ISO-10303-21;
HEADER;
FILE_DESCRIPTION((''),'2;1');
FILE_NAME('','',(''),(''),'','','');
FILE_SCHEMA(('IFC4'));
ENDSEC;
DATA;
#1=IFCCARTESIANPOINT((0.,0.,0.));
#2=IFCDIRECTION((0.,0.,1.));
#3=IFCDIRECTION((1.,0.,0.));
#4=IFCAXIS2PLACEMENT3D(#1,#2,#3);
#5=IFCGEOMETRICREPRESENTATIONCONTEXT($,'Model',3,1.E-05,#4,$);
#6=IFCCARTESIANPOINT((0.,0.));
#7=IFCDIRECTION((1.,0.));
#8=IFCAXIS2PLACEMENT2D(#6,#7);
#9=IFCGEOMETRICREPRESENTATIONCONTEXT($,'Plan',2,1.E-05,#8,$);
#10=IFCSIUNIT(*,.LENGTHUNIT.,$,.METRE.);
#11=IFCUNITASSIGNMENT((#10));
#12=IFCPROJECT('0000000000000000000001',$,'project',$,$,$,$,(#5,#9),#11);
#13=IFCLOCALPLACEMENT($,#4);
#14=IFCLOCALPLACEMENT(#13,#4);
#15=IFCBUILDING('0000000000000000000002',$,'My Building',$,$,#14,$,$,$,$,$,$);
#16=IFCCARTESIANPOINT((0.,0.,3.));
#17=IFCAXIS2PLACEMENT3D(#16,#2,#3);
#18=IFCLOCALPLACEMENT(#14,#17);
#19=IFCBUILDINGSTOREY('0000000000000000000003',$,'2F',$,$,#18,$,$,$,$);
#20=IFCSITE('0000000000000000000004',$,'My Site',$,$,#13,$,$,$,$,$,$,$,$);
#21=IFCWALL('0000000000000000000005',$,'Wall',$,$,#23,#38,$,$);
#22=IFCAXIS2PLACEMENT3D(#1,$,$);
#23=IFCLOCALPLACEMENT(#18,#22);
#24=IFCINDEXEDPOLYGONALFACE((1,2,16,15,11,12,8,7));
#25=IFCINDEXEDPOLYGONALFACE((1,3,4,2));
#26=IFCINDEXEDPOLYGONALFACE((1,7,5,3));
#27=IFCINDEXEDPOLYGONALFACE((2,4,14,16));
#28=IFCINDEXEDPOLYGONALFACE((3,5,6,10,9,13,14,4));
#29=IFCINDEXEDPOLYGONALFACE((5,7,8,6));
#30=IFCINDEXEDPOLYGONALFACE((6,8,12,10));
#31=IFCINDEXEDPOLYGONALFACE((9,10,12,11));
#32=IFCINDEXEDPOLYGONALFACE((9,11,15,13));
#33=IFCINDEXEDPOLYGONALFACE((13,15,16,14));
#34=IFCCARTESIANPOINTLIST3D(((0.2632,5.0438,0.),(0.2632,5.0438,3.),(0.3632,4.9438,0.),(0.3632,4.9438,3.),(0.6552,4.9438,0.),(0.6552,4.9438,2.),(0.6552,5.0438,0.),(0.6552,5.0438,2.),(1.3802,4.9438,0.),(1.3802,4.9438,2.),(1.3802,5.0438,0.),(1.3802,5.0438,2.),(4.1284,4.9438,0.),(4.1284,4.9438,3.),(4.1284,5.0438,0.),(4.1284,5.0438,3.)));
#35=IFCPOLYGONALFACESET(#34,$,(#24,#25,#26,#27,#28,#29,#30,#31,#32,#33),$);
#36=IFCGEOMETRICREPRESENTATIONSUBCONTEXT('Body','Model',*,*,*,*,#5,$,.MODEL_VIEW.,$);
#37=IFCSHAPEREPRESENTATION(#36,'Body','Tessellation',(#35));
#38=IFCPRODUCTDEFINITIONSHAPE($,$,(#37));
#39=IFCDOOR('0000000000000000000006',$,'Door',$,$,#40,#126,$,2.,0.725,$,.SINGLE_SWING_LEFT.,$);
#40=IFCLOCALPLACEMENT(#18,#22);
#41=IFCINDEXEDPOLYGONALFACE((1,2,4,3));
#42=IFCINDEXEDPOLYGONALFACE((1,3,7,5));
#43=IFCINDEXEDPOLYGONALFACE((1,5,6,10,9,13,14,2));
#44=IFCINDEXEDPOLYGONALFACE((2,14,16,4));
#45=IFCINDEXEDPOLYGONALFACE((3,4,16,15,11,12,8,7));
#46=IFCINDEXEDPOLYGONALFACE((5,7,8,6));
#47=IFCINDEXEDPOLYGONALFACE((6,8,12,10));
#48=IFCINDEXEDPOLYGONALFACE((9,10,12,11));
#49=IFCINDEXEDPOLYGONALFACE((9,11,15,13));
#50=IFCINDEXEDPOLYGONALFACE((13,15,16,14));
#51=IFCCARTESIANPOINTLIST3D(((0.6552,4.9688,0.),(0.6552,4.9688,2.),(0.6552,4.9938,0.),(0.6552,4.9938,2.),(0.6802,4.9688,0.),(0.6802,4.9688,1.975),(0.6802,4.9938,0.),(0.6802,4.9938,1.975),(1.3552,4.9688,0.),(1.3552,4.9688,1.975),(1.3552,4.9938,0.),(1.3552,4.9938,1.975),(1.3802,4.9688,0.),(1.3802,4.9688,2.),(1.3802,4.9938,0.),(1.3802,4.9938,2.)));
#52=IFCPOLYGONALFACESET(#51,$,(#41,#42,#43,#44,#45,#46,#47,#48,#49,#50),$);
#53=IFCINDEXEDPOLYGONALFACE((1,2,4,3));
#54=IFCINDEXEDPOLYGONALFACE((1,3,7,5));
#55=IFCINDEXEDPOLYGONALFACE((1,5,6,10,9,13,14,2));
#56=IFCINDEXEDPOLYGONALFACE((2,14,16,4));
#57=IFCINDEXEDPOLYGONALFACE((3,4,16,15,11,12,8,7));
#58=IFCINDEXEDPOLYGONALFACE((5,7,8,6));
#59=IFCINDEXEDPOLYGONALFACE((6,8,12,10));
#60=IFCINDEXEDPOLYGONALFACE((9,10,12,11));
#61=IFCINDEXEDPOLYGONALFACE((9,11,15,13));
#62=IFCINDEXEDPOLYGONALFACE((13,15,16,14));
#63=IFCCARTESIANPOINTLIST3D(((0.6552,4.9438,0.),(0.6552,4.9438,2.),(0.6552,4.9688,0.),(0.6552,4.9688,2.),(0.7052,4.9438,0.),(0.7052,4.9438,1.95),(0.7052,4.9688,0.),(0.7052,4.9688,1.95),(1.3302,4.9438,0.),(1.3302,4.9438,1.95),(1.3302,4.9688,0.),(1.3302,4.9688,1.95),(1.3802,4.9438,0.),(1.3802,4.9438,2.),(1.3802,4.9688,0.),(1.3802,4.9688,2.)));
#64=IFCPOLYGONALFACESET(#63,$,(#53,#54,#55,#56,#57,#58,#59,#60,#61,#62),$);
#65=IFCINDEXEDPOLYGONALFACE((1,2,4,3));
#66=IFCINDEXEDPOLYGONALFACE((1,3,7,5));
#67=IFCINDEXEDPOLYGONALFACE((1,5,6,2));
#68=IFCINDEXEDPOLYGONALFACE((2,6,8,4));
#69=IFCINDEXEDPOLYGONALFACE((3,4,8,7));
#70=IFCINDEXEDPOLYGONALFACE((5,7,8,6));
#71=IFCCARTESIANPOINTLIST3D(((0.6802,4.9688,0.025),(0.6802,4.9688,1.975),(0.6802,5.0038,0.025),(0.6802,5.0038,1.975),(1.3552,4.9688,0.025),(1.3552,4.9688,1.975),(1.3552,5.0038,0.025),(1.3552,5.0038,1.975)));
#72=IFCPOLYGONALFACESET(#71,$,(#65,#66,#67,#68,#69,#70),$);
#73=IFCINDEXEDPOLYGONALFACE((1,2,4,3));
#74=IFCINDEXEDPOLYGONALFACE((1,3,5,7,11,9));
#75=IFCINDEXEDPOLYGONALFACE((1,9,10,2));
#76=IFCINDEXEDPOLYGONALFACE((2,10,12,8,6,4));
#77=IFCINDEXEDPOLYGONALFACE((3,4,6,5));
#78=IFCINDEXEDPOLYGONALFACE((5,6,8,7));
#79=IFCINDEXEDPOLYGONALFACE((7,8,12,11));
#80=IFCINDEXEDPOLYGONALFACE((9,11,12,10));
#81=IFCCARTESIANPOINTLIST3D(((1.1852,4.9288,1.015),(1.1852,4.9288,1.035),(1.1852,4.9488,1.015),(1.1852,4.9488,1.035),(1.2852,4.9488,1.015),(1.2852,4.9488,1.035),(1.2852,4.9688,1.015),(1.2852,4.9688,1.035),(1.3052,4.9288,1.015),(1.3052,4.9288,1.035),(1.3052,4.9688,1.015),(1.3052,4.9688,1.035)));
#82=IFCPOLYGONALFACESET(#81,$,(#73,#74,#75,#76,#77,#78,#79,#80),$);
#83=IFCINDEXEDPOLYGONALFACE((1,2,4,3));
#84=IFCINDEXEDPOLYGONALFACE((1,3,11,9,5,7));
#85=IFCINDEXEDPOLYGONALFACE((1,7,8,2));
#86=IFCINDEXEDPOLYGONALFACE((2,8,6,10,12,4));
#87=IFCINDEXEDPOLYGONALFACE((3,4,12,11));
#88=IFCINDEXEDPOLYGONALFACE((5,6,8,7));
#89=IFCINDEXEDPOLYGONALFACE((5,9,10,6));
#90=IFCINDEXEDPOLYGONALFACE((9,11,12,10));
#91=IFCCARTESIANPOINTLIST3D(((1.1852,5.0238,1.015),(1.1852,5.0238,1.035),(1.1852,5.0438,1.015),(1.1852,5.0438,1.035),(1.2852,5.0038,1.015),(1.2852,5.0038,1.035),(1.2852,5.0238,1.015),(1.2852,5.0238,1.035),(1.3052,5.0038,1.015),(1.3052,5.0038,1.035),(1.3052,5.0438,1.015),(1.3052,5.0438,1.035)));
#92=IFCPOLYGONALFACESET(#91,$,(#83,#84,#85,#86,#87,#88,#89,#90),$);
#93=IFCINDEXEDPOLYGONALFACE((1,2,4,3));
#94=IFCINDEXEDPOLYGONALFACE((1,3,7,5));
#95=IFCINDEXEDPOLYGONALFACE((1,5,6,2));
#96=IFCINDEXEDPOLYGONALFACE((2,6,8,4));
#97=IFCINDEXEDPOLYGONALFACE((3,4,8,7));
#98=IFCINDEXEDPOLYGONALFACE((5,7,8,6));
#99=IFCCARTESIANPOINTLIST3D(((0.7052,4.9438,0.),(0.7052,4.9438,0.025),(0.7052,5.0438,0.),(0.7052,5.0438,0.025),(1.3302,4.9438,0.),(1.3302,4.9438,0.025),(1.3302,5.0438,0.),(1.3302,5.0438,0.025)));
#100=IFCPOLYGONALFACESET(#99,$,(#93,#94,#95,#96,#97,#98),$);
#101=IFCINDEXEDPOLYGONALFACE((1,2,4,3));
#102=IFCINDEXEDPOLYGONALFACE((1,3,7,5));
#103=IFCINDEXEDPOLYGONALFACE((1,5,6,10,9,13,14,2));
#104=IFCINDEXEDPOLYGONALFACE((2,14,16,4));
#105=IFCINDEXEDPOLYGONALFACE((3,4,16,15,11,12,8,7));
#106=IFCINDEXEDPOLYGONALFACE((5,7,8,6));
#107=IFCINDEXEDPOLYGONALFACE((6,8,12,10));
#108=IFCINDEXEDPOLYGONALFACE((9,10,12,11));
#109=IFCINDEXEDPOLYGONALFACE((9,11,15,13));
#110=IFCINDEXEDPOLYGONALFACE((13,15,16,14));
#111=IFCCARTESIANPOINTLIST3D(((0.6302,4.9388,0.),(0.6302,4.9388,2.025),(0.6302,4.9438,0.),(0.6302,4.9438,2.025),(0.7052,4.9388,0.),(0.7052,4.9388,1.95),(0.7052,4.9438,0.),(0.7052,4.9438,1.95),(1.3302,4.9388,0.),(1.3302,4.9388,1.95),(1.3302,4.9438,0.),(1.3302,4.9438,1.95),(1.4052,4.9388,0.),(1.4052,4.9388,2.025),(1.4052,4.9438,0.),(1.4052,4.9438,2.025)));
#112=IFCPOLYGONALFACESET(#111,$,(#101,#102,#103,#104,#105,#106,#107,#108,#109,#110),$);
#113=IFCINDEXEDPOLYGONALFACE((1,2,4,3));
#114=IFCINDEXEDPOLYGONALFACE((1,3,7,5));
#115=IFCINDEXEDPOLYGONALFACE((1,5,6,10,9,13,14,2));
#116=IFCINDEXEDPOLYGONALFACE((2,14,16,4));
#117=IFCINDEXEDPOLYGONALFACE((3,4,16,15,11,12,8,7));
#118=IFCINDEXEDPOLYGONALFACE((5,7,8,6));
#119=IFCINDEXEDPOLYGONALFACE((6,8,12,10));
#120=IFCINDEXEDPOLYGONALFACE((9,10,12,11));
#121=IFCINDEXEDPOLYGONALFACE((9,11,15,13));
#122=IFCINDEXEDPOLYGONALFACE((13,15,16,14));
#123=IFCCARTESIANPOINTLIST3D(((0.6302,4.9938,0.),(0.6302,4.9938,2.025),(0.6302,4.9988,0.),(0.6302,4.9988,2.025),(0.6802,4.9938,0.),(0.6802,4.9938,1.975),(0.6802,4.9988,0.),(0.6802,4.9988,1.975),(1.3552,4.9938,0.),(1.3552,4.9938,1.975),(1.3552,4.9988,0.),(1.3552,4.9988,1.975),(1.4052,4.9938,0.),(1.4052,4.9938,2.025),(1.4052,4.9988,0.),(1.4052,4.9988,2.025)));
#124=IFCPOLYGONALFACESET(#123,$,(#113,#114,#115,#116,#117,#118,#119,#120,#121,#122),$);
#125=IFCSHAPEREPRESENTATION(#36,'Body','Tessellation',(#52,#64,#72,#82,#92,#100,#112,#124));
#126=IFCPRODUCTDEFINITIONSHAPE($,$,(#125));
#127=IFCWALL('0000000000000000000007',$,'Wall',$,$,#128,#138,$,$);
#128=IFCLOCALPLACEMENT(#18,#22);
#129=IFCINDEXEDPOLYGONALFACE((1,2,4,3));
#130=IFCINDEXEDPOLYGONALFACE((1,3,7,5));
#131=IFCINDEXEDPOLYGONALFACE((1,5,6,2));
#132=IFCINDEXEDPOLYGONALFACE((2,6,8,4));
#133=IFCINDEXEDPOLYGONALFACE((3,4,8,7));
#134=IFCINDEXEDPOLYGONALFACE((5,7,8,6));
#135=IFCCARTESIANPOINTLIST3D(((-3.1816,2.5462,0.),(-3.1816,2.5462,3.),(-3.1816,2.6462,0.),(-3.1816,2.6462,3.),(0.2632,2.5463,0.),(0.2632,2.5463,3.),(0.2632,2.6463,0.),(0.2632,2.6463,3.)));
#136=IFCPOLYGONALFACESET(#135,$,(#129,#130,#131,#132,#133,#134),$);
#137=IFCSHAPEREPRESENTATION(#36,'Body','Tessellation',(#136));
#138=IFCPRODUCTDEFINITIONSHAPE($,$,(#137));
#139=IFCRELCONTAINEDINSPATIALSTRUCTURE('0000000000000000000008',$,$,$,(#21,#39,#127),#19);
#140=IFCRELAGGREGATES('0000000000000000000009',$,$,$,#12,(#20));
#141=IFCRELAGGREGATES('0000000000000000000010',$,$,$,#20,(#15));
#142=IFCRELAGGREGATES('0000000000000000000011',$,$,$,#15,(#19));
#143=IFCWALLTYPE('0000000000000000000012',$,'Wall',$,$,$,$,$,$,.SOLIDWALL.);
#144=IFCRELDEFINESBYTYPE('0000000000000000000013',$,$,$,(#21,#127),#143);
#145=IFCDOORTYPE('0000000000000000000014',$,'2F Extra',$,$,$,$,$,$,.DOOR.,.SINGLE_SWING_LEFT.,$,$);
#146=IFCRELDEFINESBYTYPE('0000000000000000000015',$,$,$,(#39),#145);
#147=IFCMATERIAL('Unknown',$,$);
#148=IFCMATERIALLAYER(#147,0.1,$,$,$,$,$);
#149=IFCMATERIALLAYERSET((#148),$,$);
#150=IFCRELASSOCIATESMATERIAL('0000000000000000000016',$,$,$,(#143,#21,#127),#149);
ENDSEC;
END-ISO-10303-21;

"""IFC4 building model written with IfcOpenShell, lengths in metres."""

from ifc_helpers import new_model, entity, si_unit, frame, origin_with_axes, origin_2d_with_axis, place, context, subcontext, project, spatial, line, indexed_curve, outline, extrude, shape, source, transform, mapped, material, layer, layer_set, layer_usage, type_object, type_shapes, element, fill, save


model = new_model("IFC4")

# Units and contexts
model_context = context("Model", 3, precision=1e-05, world=origin_with_axes())
plan_context = context("Plan", 2, precision=1e-05, world=origin_2d_with_axis())
body_context_1 = subcontext(model_context, "Body", "Model", "MODEL_VIEW")
body_context_2 = subcontext(plan_context, "Body", "Plan", "PLAN_VIEW")
ifc_project = project(units=[si_unit("LENGTHUNIT", "METRE")], contexts=[model_context, plan_context])

# Site, building, storey
site_placement = place(None, origin_with_axes())
site = spatial("IfcSite", under=ifc_project, at=site_placement, Name="My Site")
building_placement = place(site_placement, origin_with_axes())
building = spatial("IfcBuilding", under=site, at=building_placement, Name="My Building")
storey_placement = place(building_placement, frame((0.0, 0.0, 3.0), z_axis=(0.0, 0.0, 1.0), x_axis=(1.0, 0.0, 0.0)))
storey = spatial("IfcBuildingStorey", under=building, at=storey_placement, Name="2F")

# Shared definitions
ifc_material = material(Name="Unknown")

# Shared definitions
ifc_layer_1 = layer(ifc_material, 0.1)
ifc_layer_set_1 = layer_set([ifc_layer_1])
wall_type = type_object("IfcWallType", Name="Wall", PredefinedType="SOLIDWALL", material=ifc_layer_set_1)

# Wall, opening, door
ifc_layer_usage_1 = layer_usage(ifc_layer_set_1, "AXIS2", "POSITIVE", 0.0)
wall_1_placement = place(storey_placement, frame((4.1284, 5.0438, 0.0), z_axis=(0.0, 0.0, 1.0), x_axis=(-1.0, 0.0, 0.0)))
wall_1 = element("IfcWall", 1, at=wall_1_placement, inside=storey, type_object=wall_type, material=ifc_layer_usage_1, Name="Wall", context=body_context_1, shape_type="SweptSolid", body=[
    extrude(outline(indexed_curve([(0.0, 0.0), (0.0, 0.1), (3.7652, 0.1), (3.8652, 0.0)], segments=[line(1, 2, 3, 4, 1)])), origin_with_axes(), (0.0, 0.0, 1.0), 3.0),
])
shared_shape_1 = source(origin_with_axes(), body_context_1, "Body", "SweptSolid", [
    extrude(outline(indexed_curve([(0.0, 0.0), (0.725, 0.0), (0.725, 2.0), (0.0, 2.0)], segments=[line(1, 2, 3, 4, 1)])), frame((0.0, -0.6, 0.0), z_axis=(0.0, -1.0, 0.0), x_axis=(1.0, 0.0, 0.0)), (0.0, 0.0, -1.0), 1.2),
])
opening_1_placement = place(wall_1_placement, frame((3.4732, 0.1, 0.0), z_axis=(0.0, 0.0, 1.0), x_axis=(-1.0, 0.0, 0.0)))
opening_1 = element("IfcOpeningElement", 2, at=opening_1_placement, cuts=wall_1, PredefinedType="OPENING", context=body_context_1, shape_type="MappedRepresentation", body=[
    mapped(shared_shape_1, transform((0.0, 0.0, 0.0), x_axis=(1.0, 0.0, 0.0), y_axis=(0.0, 1.0, 0.0), z_axis=(0.0, 0.0, 1.0), scale=1.0)),
])
door_type_1 = type_object("IfcDoorType", Name="2F Extra", OperationType="SINGLE_SWING_LEFT", PredefinedType="DOOR")
shared_shape_2 = source(origin_with_axes(), body_context_1, "Body", "SweptSolid", [
    extrude(outline(indexed_curve([(0.0, 0.0), (0.0, 2.0), (0.725, 2.0), (0.725, 0.0), (0.7, 0.0), (0.7, 1.975), (0.025, 1.975), (0.025, 0.0)], segments=[line(1, 2, 3, 4, 5, 6, 7, 8, 1)])), frame((0.0, 0.025, 0.0), z_axis=(0.0, -1.0, 0.0), x_axis=(1.0, 0.0, 0.0)), (0.0, 0.0, -1.0), 0.025),
    extrude(outline(indexed_curve([(0.0, 0.0), (0.0, 2.0), (0.725, 2.0), (0.725, 0.0), (0.675, 0.0), (0.675, 1.95), (0.05, 1.95), (0.05, 0.0)], segments=[line(1, 2, 3, 4, 5, 6, 7, 8, 1)])), frame((0.0, 0.0, 0.0), z_axis=(0.0, -1.0, 0.0), x_axis=(1.0, 0.0, 0.0)), (0.0, 0.0, -1.0), 0.025),
    extrude(outline(indexed_curve([(0.0, 0.0), (0.675, 0.0), (0.675, 0.035), (0.0, 0.035)], segments=[line(1, 2, 3, 4, 1)])), frame((0.025, 0.025, 0.025), z_axis=(0.0, 0.0, 1.0), x_axis=(1.0, 0.0, 0.0)), (0.0, 0.0, 1.0), 1.95),
    extrude(outline(indexed_curve([(0.0, 0.0), (0.0, -0.04), (-0.12, -0.04), (-0.12, -0.02), (-0.02, -0.02), (-0.02, 0.0)], segments=[line(1, 2, 3, 4, 5, 6, 1)])), frame((0.65, 0.025, 1.015), z_axis=(0.0, 0.0, 1.0), x_axis=(1.0, 0.0, 0.0)), (0.0, 0.0, 1.0), 0.02),
    extrude(outline(indexed_curve([(0.0, 0.0), (0.0, 0.04), (-0.12, 0.04), (-0.12, 0.02), (-0.02, 0.02), (-0.02, 0.0)], segments=[line(1, 2, 3, 4, 5, 6, 1)])), frame((0.65, 0.06, 1.015), z_axis=(0.0, 0.0, 1.0), x_axis=(1.0, 0.0, 0.0)), (0.0, 0.0, 1.0), 0.02),
    extrude(outline(indexed_curve([(0.0, 0.0), (0.625, 0.0), (0.625, 0.1), (0.0, 0.1)], segments=[line(1, 2, 3, 4, 1)])), frame((0.05, 0.0, 0.0), z_axis=(0.0, 0.0, 1.0), x_axis=(1.0, 0.0, 0.0)), (0.0, 0.0, 1.0), 0.025),
    extrude(outline(indexed_curve([(0.0, 0.0), (0.0, 2.025), (0.775, 2.025), (0.775, 0.0), (0.7, 0.0), (0.7, 1.95), (0.075, 1.95), (0.075, 0.0)], segments=[line(1, 2, 3, 4, 5, 6, 7, 8, 1)])), frame((-0.025, -0.005, 0.0), z_axis=(0.0, -1.0, 0.0), x_axis=(1.0, 0.0, 0.0)), (0.0, 0.0, -1.0), 0.005),
    extrude(outline(indexed_curve([(0.0, 0.0), (0.0, 2.025), (0.775, 2.025), (0.775, 0.0), (0.725, 0.0), (0.725, 1.975), (0.05, 1.975), (0.05, 0.0)], segments=[line(1, 2, 3, 4, 5, 6, 7, 8, 1)])), frame((-0.025, 0.05, 0.0), z_axis=(0.0, -1.0, 0.0), x_axis=(1.0, 0.0, 0.0)), (0.0, 0.0, -1.0), 0.005),
])
shared_shape_3 = source(origin_with_axes(), body_context_2, "Body", "Curve2D", [
    entity("IfcIndexedPolyCurve", entity("IfcCartesianPointList2D", [[0.0, 0.0], [0.0, 0.05], [0.025, 0.05], [0.025, 0.025], [0.05, 0.025], [0.05, 0.0]]), [entity("IfcLineIndex", [1, 2, 3, 4, 5, 6, 1])]),
    entity("IfcIndexedPolyCurve", entity("IfcCartesianPointList2D", [[0.725, 0.0], [0.725, 0.05], [0.7, 0.05], [0.7, 0.025], [0.675, 0.025], [0.675, 0.0]]), [entity("IfcLineIndex", [1, 2, 3, 4, 5, 6, 1])]),
    entity("IfcTrimmedCurve", entity("IfcEllipse", entity("IfcAxis2Placement2D", entity("IfcCartesianPoint", [0.06, 0.05]), entity("IfcDirection", [1.0, 0.0])), 0.64, 0.675), [entity("IfcCartesianPoint", [0.7, 0.05])], [entity("IfcCartesianPoint", [0.06, 0.725])], True, "CARTESIAN"),
    entity("IfcIndexedPolyCurve", entity("IfcCartesianPointList2D", [[0.025, 0.05], [0.06, 0.05], [0.06, 0.725], [0.025, 0.725]]), [entity("IfcLineIndex", [1, 2, 3, 4, 1])]),
])
type_shapes(door_type_1, [shared_shape_2, shared_shape_3])
door_1_placement = place(opening_1_placement, frame((0.0, 0.0, 0.0), z_axis=(0.0, 0.0, 1.0), x_axis=(1.0, 0.0, 0.0)))
door_1 = element("IfcDoor", 3, at=door_1_placement, inside=storey, type_object=door_type_1, Name="Door", OperationType="SINGLE_SWING_LEFT", OverallHeight=2.0, OverallWidth=0.725, shapes=[
    shape(body_context_1, "Body", "MappedRepresentation", [mapped(shared_shape_2, transform((0.0, 0.0, 0.0), x_axis=(1.0, 0.0, 0.0), y_axis=(0.0, 1.0, 0.0), z_axis=(0.0, 0.0, 1.0), scale=1.0))]),
    shape(body_context_2, "Body", "MappedRepresentation", [mapped(shared_shape_3, transform((0.0, 0.0, 0.0), x_axis=(1.0, 0.0, 0.0), y_axis=(0.0, 1.0, 0.0), z_axis=(0.0, 0.0, 1.0), scale=1.0))]),
])
fill(opening_1, door_1)

# Wall
ifc_layer_usage_2 = layer_usage(ifc_layer_set_1, "AXIS2", "POSITIVE", 0.0)
wall_2_placement = place(storey_placement, frame((0.2632, 2.6463, 0.0), z_axis=(0.0, 0.0, 1.0), x_axis=(-1.0, 0.0, 0.0)))
element("IfcWall", 4, at=wall_2_placement, inside=storey, type_object=wall_type, material=ifc_layer_usage_2, Name="Wall", context=body_context_1, shape_type="SweptSolid", body=[
    extrude(outline(indexed_curve([(0.0, 0.0), (0.0, 0.1), (3.4448, 0.1), (3.4448, 0.0)], segments=[line(1, 2, 3, 4, 1)])), origin_with_axes(), (0.0, 0.0, 1.0), 3.0),
])

save(model, "model.ifc")
